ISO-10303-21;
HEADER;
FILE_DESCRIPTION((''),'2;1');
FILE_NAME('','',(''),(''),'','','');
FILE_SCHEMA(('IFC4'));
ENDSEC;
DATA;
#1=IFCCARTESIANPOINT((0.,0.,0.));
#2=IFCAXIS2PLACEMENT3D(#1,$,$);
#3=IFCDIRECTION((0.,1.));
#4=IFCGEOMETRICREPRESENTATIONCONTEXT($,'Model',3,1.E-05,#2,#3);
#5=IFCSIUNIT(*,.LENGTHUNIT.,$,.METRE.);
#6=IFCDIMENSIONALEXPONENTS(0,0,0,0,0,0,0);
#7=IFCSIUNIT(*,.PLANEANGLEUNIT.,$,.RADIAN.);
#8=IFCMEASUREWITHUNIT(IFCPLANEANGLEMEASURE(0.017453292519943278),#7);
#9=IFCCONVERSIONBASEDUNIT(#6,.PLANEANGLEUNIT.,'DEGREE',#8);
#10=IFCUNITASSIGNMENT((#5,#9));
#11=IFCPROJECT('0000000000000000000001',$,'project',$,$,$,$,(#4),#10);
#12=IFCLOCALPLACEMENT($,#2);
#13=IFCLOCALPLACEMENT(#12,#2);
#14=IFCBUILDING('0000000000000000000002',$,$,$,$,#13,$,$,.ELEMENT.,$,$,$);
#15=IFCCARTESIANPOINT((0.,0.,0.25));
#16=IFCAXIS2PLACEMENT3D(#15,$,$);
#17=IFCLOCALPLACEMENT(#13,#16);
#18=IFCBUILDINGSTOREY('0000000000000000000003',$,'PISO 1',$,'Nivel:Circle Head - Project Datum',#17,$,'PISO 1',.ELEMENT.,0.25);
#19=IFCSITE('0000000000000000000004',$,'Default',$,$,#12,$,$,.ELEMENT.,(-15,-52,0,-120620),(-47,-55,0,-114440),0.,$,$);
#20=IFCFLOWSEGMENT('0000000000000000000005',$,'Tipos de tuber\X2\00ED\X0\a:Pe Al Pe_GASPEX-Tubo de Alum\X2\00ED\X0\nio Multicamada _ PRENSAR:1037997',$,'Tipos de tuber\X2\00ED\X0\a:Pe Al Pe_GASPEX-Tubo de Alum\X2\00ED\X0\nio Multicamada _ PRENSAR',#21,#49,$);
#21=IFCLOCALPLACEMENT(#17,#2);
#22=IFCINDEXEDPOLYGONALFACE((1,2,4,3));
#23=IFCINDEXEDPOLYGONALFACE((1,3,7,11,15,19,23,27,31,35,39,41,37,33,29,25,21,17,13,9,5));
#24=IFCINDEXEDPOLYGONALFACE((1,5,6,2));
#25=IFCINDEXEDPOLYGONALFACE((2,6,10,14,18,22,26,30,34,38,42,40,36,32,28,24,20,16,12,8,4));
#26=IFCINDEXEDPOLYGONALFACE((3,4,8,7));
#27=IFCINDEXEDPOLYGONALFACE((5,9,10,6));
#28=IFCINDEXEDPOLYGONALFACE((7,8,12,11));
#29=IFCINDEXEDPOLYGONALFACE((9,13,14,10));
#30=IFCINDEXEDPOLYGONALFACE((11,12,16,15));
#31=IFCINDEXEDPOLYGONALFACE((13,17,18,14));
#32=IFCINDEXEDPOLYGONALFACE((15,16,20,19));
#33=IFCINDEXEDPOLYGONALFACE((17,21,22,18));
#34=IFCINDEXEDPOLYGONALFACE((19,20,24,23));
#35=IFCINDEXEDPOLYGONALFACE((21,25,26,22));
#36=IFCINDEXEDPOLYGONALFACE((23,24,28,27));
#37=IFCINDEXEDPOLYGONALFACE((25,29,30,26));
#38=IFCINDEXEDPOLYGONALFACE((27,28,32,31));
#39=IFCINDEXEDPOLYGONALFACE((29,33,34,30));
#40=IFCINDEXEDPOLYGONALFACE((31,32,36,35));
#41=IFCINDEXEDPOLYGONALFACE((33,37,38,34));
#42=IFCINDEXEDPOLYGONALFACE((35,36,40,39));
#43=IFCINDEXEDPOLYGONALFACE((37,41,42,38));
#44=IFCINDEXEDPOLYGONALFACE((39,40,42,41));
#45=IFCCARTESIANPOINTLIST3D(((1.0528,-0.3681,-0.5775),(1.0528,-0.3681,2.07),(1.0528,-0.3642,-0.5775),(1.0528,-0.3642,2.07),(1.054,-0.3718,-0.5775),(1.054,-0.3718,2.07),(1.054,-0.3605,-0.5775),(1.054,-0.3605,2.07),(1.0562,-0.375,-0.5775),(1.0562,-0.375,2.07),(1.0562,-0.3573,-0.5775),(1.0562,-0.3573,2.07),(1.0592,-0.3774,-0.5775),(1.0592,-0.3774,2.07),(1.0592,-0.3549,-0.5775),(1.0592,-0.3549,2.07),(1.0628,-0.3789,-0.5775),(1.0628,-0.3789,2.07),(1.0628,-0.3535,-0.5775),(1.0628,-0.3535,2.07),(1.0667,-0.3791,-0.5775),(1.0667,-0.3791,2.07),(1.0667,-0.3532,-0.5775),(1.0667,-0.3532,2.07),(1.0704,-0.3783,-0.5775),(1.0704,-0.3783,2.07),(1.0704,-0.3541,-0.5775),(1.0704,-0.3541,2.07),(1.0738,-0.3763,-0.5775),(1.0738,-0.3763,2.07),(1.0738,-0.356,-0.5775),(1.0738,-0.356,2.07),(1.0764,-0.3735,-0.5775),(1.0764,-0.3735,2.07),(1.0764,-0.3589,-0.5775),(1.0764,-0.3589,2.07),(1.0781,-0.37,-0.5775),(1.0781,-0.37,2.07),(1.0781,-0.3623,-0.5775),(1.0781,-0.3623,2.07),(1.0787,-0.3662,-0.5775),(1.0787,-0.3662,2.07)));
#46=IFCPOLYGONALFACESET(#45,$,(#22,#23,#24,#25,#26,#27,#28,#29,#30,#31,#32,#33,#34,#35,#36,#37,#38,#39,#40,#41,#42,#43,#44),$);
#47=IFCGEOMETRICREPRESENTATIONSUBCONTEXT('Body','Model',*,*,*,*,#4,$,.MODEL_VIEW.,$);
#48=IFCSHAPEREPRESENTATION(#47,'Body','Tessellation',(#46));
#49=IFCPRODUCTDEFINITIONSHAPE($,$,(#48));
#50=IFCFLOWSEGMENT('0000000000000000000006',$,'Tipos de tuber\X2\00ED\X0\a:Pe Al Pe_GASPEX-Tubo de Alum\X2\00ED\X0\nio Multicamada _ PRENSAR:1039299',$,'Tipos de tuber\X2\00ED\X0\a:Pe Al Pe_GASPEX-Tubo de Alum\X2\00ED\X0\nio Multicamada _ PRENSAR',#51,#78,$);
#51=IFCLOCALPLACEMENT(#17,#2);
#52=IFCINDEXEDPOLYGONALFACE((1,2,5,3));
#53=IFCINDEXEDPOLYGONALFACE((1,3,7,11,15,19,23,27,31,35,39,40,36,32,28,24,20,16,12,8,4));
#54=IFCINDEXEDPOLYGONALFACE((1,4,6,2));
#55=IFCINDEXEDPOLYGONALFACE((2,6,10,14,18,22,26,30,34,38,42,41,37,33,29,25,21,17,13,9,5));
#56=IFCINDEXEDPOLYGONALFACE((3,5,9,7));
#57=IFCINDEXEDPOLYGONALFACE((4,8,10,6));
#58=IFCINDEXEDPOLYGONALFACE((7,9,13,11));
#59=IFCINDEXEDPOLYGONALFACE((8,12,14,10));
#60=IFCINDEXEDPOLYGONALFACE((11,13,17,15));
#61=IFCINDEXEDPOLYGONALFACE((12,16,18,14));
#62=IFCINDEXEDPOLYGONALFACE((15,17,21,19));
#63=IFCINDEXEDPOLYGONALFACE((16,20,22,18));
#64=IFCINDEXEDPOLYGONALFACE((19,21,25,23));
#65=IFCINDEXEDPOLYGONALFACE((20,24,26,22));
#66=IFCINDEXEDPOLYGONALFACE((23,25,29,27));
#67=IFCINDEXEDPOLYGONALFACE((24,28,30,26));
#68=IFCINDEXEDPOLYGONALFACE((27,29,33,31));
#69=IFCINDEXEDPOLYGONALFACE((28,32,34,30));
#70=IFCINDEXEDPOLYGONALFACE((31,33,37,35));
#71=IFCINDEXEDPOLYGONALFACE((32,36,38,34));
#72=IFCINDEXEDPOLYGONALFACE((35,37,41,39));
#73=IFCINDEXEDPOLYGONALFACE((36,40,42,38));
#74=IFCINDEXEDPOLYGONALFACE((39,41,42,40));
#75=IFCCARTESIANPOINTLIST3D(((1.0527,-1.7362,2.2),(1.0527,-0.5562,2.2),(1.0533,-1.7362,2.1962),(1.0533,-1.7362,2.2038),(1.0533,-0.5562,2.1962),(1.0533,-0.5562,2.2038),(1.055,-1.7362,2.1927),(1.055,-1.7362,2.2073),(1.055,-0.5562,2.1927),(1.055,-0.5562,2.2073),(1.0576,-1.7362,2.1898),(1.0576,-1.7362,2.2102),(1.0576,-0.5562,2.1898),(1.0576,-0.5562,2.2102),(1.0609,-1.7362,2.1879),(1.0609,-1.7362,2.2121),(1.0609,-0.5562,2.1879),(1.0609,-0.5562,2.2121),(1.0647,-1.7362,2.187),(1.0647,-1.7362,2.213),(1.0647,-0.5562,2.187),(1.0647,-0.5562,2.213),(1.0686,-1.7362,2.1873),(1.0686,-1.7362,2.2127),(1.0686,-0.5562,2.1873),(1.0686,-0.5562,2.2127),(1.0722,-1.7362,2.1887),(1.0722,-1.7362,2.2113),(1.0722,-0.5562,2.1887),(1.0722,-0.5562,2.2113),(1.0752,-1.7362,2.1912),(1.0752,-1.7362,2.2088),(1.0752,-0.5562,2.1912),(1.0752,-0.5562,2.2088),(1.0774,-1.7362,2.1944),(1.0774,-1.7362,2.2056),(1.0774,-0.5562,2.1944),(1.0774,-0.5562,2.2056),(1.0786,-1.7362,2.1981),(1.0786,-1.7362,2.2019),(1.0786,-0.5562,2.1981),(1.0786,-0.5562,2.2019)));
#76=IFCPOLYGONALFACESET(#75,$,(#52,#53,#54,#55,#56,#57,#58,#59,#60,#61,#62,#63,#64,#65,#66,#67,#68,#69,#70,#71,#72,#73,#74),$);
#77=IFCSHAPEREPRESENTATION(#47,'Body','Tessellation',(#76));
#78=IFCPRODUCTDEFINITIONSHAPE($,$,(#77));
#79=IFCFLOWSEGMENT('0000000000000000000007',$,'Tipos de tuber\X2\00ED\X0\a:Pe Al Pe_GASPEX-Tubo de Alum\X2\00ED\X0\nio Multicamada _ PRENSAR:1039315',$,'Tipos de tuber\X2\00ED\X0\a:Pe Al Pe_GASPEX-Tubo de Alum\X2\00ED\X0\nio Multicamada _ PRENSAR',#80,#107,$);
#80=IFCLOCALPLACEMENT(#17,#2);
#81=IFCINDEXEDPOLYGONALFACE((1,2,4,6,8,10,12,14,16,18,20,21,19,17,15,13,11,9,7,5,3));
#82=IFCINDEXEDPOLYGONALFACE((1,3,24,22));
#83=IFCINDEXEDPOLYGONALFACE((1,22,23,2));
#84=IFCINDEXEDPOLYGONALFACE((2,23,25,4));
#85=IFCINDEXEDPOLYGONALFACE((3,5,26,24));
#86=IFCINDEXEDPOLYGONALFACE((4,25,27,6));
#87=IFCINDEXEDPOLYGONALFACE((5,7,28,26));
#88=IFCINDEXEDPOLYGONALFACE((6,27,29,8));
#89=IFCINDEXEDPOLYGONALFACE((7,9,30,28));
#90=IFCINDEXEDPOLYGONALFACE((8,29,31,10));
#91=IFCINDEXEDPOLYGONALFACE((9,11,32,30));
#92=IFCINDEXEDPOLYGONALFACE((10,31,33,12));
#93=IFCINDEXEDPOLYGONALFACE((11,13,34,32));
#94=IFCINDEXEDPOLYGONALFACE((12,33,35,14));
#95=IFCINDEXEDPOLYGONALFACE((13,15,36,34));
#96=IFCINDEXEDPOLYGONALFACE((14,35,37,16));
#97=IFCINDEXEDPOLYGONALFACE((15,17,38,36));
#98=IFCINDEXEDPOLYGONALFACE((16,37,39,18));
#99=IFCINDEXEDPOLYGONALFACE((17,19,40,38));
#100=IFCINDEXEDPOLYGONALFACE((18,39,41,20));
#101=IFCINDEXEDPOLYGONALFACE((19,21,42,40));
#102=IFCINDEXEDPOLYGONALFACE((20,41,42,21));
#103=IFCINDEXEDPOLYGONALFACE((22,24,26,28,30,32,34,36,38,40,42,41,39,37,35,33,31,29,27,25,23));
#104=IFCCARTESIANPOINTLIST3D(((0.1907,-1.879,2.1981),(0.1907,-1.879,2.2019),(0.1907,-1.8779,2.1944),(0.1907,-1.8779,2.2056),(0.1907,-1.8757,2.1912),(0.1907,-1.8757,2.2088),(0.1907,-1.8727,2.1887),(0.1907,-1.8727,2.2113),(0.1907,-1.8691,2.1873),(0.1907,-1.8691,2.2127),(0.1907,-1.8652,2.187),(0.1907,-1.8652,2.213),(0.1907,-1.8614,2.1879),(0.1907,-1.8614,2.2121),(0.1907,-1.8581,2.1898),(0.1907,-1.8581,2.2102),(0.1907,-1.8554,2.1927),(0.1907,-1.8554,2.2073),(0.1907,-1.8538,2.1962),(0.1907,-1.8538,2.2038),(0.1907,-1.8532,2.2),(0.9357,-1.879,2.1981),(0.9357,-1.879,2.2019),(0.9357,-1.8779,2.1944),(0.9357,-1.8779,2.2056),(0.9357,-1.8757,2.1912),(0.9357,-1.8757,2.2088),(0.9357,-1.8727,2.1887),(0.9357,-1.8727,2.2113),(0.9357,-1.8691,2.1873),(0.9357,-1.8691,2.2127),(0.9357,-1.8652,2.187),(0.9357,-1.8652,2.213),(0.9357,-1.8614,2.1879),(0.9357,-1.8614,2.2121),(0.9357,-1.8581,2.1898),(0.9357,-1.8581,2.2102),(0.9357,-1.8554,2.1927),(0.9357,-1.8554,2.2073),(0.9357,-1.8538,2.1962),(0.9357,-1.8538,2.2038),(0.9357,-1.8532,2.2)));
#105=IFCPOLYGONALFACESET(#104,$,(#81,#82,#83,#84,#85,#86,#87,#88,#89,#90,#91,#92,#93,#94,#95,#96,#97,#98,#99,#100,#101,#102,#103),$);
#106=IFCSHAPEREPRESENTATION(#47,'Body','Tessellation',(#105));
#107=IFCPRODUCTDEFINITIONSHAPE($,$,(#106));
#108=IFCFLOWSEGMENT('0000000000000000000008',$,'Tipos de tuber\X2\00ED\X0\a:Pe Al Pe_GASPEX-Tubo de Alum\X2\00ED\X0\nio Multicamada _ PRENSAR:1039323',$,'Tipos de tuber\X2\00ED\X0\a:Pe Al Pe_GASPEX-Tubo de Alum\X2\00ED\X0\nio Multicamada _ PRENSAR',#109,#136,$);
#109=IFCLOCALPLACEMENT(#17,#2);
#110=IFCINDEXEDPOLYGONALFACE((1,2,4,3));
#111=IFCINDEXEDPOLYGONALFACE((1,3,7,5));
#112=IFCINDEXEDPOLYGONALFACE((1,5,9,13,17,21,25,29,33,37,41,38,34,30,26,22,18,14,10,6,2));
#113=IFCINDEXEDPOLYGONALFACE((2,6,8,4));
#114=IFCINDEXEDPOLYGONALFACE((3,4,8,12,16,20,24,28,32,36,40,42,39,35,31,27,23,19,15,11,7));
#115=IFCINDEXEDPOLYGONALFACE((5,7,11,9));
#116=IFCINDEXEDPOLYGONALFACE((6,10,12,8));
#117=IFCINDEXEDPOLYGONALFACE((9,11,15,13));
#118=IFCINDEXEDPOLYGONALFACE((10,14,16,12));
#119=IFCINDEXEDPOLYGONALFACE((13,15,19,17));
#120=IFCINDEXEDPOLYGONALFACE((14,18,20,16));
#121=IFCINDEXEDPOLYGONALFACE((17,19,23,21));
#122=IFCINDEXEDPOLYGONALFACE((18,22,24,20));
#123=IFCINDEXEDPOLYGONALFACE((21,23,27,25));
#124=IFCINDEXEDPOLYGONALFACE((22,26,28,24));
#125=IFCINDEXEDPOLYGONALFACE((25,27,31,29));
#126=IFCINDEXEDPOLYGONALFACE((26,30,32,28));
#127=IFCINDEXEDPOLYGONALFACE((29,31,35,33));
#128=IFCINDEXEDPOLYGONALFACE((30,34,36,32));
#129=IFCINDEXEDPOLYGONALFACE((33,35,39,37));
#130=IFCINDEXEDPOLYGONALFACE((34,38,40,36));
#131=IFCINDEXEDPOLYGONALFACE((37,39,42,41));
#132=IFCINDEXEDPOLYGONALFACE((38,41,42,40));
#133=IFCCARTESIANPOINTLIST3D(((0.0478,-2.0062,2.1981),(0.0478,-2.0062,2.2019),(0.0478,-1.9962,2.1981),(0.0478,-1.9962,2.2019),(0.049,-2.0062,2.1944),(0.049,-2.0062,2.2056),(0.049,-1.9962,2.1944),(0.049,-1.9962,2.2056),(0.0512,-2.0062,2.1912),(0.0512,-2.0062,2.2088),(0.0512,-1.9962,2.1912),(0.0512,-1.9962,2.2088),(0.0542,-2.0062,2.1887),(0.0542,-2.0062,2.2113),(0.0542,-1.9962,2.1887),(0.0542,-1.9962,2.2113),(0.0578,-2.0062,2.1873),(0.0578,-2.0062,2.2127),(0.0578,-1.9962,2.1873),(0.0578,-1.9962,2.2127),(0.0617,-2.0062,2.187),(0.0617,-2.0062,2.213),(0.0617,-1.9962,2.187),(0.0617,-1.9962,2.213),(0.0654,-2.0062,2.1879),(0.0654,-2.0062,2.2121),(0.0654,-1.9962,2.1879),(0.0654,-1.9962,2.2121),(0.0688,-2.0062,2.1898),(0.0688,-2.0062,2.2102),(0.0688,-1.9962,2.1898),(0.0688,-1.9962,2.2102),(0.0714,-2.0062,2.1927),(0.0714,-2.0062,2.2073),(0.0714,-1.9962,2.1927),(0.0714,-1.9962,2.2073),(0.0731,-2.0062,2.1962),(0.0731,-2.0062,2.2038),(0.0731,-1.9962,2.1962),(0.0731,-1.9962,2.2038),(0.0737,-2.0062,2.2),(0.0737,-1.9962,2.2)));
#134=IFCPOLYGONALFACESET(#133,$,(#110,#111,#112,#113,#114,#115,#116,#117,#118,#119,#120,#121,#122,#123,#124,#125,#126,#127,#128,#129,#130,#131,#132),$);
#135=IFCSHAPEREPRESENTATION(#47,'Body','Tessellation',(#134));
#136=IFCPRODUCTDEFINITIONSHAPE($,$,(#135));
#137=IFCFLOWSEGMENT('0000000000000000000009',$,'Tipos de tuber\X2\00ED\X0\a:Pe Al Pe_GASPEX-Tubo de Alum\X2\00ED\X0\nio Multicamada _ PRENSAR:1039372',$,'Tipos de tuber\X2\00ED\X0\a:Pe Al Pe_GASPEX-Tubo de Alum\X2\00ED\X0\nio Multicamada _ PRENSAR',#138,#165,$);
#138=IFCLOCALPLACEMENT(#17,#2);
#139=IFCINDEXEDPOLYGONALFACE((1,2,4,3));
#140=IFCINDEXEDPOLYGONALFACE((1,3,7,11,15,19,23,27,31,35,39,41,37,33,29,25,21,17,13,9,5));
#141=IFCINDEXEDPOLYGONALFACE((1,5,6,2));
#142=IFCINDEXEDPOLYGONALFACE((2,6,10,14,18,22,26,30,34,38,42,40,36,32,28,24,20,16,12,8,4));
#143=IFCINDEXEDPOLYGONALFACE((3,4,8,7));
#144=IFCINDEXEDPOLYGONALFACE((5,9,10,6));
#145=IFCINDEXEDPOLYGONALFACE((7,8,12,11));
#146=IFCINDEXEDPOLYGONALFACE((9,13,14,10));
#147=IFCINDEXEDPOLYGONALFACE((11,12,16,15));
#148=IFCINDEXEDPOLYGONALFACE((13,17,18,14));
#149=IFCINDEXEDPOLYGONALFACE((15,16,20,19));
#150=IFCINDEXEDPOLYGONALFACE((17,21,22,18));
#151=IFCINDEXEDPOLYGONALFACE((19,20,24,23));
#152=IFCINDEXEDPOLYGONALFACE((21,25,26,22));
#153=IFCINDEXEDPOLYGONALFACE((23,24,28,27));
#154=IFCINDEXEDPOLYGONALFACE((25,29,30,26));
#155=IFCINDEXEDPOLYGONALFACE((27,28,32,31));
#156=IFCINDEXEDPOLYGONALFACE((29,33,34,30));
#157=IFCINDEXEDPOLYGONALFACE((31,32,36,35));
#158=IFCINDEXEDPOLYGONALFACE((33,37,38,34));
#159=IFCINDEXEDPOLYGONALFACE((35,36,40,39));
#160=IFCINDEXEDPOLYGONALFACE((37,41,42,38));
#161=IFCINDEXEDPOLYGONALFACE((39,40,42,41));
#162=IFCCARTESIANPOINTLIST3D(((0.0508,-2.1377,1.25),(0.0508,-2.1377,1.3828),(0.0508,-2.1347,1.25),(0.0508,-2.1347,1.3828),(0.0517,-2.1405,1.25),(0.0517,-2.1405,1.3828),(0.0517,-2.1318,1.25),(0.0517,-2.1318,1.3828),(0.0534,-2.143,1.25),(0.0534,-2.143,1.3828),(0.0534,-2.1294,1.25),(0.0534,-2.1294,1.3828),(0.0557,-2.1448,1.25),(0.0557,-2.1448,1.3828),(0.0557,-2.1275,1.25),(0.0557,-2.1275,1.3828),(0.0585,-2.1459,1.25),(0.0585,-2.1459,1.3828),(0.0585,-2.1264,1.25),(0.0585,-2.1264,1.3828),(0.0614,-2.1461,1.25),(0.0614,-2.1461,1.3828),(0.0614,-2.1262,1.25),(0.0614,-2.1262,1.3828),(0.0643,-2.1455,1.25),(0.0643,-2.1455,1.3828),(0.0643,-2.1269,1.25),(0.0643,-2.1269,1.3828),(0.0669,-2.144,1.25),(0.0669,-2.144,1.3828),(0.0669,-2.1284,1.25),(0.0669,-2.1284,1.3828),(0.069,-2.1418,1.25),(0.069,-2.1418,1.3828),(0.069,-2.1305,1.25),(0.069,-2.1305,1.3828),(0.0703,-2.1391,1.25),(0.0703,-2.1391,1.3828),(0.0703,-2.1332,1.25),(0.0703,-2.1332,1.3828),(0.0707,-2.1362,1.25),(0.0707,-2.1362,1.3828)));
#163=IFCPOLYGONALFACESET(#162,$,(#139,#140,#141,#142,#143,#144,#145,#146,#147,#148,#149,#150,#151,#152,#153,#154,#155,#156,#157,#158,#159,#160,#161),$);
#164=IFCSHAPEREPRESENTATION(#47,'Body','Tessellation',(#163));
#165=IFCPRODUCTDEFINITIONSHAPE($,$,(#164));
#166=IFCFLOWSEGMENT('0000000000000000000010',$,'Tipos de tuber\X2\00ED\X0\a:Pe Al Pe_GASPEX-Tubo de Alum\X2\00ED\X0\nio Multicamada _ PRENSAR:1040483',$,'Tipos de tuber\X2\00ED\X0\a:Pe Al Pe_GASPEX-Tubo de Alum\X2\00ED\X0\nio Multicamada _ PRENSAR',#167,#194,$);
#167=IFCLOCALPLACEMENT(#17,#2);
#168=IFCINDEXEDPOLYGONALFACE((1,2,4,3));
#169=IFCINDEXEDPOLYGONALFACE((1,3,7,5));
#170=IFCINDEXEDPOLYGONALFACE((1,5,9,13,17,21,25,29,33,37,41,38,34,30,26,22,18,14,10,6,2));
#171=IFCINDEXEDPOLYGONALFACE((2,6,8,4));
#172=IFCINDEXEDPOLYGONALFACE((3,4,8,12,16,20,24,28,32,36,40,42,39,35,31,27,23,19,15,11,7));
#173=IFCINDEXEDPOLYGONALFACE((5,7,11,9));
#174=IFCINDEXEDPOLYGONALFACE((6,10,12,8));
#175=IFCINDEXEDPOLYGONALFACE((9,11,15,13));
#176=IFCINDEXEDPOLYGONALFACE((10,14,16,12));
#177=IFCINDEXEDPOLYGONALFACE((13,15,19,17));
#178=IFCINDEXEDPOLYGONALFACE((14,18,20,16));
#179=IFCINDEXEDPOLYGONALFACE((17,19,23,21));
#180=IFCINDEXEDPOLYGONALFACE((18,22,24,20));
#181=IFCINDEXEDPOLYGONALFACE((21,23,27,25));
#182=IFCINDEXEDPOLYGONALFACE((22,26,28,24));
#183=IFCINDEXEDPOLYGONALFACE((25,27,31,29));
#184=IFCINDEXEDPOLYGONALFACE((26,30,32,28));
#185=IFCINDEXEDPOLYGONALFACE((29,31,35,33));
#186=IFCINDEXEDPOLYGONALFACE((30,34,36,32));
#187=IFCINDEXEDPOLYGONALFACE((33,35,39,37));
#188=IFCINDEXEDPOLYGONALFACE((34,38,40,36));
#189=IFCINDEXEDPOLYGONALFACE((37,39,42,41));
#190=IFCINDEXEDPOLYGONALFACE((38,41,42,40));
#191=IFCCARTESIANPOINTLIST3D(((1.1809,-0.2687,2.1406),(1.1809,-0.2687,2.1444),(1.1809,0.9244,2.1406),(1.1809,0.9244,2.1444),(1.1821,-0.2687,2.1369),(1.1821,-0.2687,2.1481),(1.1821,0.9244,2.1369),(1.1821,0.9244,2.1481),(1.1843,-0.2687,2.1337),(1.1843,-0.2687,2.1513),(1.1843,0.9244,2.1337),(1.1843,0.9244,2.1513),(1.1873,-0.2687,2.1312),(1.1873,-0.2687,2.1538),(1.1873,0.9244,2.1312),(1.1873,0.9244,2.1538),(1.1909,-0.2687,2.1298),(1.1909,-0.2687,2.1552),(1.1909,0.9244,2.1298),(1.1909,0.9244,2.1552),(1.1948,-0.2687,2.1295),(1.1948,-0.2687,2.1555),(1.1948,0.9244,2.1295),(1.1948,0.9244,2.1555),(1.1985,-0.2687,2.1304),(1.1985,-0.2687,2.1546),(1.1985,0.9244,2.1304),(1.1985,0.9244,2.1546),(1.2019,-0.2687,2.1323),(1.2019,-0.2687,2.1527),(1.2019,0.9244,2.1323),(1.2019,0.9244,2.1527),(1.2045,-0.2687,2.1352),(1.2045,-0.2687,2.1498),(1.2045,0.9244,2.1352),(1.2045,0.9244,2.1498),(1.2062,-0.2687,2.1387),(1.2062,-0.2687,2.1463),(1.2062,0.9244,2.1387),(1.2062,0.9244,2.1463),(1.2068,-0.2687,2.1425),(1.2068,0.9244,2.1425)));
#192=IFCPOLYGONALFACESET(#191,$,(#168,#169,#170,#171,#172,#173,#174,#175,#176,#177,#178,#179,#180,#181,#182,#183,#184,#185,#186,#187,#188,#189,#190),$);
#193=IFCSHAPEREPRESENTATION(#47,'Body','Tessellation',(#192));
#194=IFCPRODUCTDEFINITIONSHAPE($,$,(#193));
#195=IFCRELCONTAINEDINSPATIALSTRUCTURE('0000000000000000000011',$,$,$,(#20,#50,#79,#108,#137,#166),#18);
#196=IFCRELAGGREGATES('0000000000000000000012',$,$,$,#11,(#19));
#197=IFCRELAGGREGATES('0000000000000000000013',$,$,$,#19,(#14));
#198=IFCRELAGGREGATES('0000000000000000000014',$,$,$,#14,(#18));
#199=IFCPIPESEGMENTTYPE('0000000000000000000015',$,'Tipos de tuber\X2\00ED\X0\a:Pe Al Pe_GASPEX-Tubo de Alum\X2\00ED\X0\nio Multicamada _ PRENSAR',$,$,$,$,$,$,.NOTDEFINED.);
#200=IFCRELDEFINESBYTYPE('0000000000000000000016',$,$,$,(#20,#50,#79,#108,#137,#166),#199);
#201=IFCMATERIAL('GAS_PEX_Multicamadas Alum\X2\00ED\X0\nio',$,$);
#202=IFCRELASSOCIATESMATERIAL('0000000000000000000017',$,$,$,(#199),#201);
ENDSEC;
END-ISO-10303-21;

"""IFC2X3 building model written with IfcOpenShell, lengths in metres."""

from ifc_helpers import new_model, entity, si_unit, converted_unit, direction, frame, frame_2d, origin, origin_2d_with_axis, place, context, subcontext, project, spatial, circle, extrude, material, type_object, element, save


model = new_model("IFC2X3")

# Units and contexts
model_context = context("Model", 3, precision=1e-05, world=origin(), true_north=direction((0.0, 1.0)))
body_context = subcontext(model_context, "Body", "Model", "MODEL_VIEW")
ifc_project = project(units=[si_unit("LENGTHUNIT", "METRE"), converted_unit("PLANEANGLEUNIT", "DEGREE", entity("IfcPlaneAngleMeasure", 0.017453292519943278), si_unit("PLANEANGLEUNIT", "RADIAN"), dimensions=[0, 0, 0, 0, 0, 0, 0])], contexts=[model_context])

# Site, building, storey
site_placement = place(None, origin())
site = spatial("IfcSite", under=ifc_project, at=site_placement, Name="Default", CompositionType="ELEMENT", RefLatitude=(-15, -52, 0, -120620), RefLongitude=(-47, -55, 0, -114440), RefElevation=0.0)
building_placement = place(site_placement, origin())
building = spatial("IfcBuilding", under=site, at=building_placement, CompositionType="ELEMENT")
storey_placement = place(building_placement, frame((0.0, 0.0, 0.25)))
storey = spatial("IfcBuildingStorey", under=building, at=storey_placement, Name="PISO 1", ObjectType="Nivel:Circle Head - Project Datum", LongName="PISO 1", CompositionType="ELEMENT", Elevation=0.25)

# Flow segments
ifc_material = material(Name="GAS_PEX_Multicamadas Alumínio")
pipe_segment_type = type_object("IfcPipeSegmentType", Name="Tipos de tubería:Pe Al Pe_GASPEX-Tubo de Alumínio Multicamada _ PRENSAR", PredefinedType="NOTDEFINED", material=ifc_material)
flow_segment_1_placement = place(storey_placement, origin())
element("IfcFlowSegment", 1, at=flow_segment_1_placement, inside=storey, type_object=pipe_segment_type, Name="Tipos de tubería:Pe Al Pe_GASPEX-Tubo de Alumínio Multicamada _ PRENSAR:1037997", ObjectType="Tipos de tubería:Pe Al Pe_GASPEX-Tubo de Alumínio Multicamada _ PRENSAR", context=body_context, shape_type="SweptSolid", body=[
    extrude(circle(Radius=0.013, at=origin_2d_with_axis()), frame((1.0657, -0.3662, -0.5775)), (0.0, 0.0, 1.0), 2.6475),
])
flow_segment_2_placement = place(storey_placement, origin())
element("IfcFlowSegment", 2, at=flow_segment_2_placement, inside=storey, type_object=pipe_segment_type, Name="Tipos de tubería:Pe Al Pe_GASPEX-Tubo de Alumínio Multicamada _ PRENSAR:1039299", ObjectType="Tipos de tubería:Pe Al Pe_GASPEX-Tubo de Alumínio Multicamada _ PRENSAR", context=body_context, shape_type="SweptSolid", body=[
    extrude(circle(Radius=0.013, at=origin_2d_with_axis()), frame((1.0657, -1.7362, 2.2), z_axis=(0.0, 1.0, 0.0), x_axis=(-1.0, 0.0, 0.0)), (0.0, 0.0, 1.0), 1.18),
])
flow_segment_3_placement = place(storey_placement, origin())
element("IfcFlowSegment", 3, at=flow_segment_3_placement, inside=storey, type_object=pipe_segment_type, Name="Tipos de tubería:Pe Al Pe_GASPEX-Tubo de Alumínio Multicamada _ PRENSAR:1039315", ObjectType="Tipos de tubería:Pe Al Pe_GASPEX-Tubo de Alumínio Multicamada _ PRENSAR", context=body_context, shape_type="SweptSolid", body=[
    extrude(circle(Radius=0.013, at=origin_2d_with_axis()), frame((0.1907, -1.8662, 2.2), z_axis=(1.0, 0.0, 0.0), x_axis=(0.0, 1.0, 0.0)), (0.0, 0.0, 1.0), 0.745),
])
flow_segment_4_placement = place(storey_placement, origin())
element("IfcFlowSegment", 4, at=flow_segment_4_placement, inside=storey, type_object=pipe_segment_type, Name="Tipos de tubería:Pe Al Pe_GASPEX-Tubo de Alumínio Multicamada _ PRENSAR:1039323", ObjectType="Tipos de tubería:Pe Al Pe_GASPEX-Tubo de Alumínio Multicamada _ PRENSAR", context=body_context, shape_type="SweptSolid", body=[
    extrude(circle(Radius=0.013, at=frame_2d((0.0, 0.0), x_axis=(1.0, 0.0))), frame((0.0607, -2.0062, 2.2), z_axis=(0.0, 1.0, 0.0), x_axis=(1.0, 0.0, 0.0)), (0.0, 0.0, 1.0), 0.01),
])
flow_segment_5_placement = place(storey_placement, origin())
element("IfcFlowSegment", 5, at=flow_segment_5_placement, inside=storey, type_object=pipe_segment_type, Name="Tipos de tubería:Pe Al Pe_GASPEX-Tubo de Alumínio Multicamada _ PRENSAR:1039372", ObjectType="Tipos de tubería:Pe Al Pe_GASPEX-Tubo de Alumínio Multicamada _ PRENSAR", context=body_context, shape_type="SweptSolid", body=[
    extrude(circle(Radius=0.01, at=frame_2d((0.0, 0.0), x_axis=(1.0, 0.0))), frame((0.0607, -2.1362, 1.25)), (0.0, 0.0, 1.0), 0.1329),
])
flow_segment_6_placement = place(storey_placement, origin())
element("IfcFlowSegment", 6, at=flow_segment_6_placement, inside=storey, type_object=pipe_segment_type, Name="Tipos de tubería:Pe Al Pe_GASPEX-Tubo de Alumínio Multicamada _ PRENSAR:1040483", ObjectType="Tipos de tubería:Pe Al Pe_GASPEX-Tubo de Alumínio Multicamada _ PRENSAR", context=body_context, shape_type="SweptSolid", body=[
    extrude(circle(Radius=0.013, at=frame_2d((0.0, 0.0), x_axis=(1.0, 0.0))), frame((1.1938, -0.2687, 2.1425), z_axis=(0.0, 1.0, 0.0), x_axis=(1.0, 0.0, 0.0)), (0.0, 0.0, 1.0), 1.193),
])

save(model, "model.ifc")
